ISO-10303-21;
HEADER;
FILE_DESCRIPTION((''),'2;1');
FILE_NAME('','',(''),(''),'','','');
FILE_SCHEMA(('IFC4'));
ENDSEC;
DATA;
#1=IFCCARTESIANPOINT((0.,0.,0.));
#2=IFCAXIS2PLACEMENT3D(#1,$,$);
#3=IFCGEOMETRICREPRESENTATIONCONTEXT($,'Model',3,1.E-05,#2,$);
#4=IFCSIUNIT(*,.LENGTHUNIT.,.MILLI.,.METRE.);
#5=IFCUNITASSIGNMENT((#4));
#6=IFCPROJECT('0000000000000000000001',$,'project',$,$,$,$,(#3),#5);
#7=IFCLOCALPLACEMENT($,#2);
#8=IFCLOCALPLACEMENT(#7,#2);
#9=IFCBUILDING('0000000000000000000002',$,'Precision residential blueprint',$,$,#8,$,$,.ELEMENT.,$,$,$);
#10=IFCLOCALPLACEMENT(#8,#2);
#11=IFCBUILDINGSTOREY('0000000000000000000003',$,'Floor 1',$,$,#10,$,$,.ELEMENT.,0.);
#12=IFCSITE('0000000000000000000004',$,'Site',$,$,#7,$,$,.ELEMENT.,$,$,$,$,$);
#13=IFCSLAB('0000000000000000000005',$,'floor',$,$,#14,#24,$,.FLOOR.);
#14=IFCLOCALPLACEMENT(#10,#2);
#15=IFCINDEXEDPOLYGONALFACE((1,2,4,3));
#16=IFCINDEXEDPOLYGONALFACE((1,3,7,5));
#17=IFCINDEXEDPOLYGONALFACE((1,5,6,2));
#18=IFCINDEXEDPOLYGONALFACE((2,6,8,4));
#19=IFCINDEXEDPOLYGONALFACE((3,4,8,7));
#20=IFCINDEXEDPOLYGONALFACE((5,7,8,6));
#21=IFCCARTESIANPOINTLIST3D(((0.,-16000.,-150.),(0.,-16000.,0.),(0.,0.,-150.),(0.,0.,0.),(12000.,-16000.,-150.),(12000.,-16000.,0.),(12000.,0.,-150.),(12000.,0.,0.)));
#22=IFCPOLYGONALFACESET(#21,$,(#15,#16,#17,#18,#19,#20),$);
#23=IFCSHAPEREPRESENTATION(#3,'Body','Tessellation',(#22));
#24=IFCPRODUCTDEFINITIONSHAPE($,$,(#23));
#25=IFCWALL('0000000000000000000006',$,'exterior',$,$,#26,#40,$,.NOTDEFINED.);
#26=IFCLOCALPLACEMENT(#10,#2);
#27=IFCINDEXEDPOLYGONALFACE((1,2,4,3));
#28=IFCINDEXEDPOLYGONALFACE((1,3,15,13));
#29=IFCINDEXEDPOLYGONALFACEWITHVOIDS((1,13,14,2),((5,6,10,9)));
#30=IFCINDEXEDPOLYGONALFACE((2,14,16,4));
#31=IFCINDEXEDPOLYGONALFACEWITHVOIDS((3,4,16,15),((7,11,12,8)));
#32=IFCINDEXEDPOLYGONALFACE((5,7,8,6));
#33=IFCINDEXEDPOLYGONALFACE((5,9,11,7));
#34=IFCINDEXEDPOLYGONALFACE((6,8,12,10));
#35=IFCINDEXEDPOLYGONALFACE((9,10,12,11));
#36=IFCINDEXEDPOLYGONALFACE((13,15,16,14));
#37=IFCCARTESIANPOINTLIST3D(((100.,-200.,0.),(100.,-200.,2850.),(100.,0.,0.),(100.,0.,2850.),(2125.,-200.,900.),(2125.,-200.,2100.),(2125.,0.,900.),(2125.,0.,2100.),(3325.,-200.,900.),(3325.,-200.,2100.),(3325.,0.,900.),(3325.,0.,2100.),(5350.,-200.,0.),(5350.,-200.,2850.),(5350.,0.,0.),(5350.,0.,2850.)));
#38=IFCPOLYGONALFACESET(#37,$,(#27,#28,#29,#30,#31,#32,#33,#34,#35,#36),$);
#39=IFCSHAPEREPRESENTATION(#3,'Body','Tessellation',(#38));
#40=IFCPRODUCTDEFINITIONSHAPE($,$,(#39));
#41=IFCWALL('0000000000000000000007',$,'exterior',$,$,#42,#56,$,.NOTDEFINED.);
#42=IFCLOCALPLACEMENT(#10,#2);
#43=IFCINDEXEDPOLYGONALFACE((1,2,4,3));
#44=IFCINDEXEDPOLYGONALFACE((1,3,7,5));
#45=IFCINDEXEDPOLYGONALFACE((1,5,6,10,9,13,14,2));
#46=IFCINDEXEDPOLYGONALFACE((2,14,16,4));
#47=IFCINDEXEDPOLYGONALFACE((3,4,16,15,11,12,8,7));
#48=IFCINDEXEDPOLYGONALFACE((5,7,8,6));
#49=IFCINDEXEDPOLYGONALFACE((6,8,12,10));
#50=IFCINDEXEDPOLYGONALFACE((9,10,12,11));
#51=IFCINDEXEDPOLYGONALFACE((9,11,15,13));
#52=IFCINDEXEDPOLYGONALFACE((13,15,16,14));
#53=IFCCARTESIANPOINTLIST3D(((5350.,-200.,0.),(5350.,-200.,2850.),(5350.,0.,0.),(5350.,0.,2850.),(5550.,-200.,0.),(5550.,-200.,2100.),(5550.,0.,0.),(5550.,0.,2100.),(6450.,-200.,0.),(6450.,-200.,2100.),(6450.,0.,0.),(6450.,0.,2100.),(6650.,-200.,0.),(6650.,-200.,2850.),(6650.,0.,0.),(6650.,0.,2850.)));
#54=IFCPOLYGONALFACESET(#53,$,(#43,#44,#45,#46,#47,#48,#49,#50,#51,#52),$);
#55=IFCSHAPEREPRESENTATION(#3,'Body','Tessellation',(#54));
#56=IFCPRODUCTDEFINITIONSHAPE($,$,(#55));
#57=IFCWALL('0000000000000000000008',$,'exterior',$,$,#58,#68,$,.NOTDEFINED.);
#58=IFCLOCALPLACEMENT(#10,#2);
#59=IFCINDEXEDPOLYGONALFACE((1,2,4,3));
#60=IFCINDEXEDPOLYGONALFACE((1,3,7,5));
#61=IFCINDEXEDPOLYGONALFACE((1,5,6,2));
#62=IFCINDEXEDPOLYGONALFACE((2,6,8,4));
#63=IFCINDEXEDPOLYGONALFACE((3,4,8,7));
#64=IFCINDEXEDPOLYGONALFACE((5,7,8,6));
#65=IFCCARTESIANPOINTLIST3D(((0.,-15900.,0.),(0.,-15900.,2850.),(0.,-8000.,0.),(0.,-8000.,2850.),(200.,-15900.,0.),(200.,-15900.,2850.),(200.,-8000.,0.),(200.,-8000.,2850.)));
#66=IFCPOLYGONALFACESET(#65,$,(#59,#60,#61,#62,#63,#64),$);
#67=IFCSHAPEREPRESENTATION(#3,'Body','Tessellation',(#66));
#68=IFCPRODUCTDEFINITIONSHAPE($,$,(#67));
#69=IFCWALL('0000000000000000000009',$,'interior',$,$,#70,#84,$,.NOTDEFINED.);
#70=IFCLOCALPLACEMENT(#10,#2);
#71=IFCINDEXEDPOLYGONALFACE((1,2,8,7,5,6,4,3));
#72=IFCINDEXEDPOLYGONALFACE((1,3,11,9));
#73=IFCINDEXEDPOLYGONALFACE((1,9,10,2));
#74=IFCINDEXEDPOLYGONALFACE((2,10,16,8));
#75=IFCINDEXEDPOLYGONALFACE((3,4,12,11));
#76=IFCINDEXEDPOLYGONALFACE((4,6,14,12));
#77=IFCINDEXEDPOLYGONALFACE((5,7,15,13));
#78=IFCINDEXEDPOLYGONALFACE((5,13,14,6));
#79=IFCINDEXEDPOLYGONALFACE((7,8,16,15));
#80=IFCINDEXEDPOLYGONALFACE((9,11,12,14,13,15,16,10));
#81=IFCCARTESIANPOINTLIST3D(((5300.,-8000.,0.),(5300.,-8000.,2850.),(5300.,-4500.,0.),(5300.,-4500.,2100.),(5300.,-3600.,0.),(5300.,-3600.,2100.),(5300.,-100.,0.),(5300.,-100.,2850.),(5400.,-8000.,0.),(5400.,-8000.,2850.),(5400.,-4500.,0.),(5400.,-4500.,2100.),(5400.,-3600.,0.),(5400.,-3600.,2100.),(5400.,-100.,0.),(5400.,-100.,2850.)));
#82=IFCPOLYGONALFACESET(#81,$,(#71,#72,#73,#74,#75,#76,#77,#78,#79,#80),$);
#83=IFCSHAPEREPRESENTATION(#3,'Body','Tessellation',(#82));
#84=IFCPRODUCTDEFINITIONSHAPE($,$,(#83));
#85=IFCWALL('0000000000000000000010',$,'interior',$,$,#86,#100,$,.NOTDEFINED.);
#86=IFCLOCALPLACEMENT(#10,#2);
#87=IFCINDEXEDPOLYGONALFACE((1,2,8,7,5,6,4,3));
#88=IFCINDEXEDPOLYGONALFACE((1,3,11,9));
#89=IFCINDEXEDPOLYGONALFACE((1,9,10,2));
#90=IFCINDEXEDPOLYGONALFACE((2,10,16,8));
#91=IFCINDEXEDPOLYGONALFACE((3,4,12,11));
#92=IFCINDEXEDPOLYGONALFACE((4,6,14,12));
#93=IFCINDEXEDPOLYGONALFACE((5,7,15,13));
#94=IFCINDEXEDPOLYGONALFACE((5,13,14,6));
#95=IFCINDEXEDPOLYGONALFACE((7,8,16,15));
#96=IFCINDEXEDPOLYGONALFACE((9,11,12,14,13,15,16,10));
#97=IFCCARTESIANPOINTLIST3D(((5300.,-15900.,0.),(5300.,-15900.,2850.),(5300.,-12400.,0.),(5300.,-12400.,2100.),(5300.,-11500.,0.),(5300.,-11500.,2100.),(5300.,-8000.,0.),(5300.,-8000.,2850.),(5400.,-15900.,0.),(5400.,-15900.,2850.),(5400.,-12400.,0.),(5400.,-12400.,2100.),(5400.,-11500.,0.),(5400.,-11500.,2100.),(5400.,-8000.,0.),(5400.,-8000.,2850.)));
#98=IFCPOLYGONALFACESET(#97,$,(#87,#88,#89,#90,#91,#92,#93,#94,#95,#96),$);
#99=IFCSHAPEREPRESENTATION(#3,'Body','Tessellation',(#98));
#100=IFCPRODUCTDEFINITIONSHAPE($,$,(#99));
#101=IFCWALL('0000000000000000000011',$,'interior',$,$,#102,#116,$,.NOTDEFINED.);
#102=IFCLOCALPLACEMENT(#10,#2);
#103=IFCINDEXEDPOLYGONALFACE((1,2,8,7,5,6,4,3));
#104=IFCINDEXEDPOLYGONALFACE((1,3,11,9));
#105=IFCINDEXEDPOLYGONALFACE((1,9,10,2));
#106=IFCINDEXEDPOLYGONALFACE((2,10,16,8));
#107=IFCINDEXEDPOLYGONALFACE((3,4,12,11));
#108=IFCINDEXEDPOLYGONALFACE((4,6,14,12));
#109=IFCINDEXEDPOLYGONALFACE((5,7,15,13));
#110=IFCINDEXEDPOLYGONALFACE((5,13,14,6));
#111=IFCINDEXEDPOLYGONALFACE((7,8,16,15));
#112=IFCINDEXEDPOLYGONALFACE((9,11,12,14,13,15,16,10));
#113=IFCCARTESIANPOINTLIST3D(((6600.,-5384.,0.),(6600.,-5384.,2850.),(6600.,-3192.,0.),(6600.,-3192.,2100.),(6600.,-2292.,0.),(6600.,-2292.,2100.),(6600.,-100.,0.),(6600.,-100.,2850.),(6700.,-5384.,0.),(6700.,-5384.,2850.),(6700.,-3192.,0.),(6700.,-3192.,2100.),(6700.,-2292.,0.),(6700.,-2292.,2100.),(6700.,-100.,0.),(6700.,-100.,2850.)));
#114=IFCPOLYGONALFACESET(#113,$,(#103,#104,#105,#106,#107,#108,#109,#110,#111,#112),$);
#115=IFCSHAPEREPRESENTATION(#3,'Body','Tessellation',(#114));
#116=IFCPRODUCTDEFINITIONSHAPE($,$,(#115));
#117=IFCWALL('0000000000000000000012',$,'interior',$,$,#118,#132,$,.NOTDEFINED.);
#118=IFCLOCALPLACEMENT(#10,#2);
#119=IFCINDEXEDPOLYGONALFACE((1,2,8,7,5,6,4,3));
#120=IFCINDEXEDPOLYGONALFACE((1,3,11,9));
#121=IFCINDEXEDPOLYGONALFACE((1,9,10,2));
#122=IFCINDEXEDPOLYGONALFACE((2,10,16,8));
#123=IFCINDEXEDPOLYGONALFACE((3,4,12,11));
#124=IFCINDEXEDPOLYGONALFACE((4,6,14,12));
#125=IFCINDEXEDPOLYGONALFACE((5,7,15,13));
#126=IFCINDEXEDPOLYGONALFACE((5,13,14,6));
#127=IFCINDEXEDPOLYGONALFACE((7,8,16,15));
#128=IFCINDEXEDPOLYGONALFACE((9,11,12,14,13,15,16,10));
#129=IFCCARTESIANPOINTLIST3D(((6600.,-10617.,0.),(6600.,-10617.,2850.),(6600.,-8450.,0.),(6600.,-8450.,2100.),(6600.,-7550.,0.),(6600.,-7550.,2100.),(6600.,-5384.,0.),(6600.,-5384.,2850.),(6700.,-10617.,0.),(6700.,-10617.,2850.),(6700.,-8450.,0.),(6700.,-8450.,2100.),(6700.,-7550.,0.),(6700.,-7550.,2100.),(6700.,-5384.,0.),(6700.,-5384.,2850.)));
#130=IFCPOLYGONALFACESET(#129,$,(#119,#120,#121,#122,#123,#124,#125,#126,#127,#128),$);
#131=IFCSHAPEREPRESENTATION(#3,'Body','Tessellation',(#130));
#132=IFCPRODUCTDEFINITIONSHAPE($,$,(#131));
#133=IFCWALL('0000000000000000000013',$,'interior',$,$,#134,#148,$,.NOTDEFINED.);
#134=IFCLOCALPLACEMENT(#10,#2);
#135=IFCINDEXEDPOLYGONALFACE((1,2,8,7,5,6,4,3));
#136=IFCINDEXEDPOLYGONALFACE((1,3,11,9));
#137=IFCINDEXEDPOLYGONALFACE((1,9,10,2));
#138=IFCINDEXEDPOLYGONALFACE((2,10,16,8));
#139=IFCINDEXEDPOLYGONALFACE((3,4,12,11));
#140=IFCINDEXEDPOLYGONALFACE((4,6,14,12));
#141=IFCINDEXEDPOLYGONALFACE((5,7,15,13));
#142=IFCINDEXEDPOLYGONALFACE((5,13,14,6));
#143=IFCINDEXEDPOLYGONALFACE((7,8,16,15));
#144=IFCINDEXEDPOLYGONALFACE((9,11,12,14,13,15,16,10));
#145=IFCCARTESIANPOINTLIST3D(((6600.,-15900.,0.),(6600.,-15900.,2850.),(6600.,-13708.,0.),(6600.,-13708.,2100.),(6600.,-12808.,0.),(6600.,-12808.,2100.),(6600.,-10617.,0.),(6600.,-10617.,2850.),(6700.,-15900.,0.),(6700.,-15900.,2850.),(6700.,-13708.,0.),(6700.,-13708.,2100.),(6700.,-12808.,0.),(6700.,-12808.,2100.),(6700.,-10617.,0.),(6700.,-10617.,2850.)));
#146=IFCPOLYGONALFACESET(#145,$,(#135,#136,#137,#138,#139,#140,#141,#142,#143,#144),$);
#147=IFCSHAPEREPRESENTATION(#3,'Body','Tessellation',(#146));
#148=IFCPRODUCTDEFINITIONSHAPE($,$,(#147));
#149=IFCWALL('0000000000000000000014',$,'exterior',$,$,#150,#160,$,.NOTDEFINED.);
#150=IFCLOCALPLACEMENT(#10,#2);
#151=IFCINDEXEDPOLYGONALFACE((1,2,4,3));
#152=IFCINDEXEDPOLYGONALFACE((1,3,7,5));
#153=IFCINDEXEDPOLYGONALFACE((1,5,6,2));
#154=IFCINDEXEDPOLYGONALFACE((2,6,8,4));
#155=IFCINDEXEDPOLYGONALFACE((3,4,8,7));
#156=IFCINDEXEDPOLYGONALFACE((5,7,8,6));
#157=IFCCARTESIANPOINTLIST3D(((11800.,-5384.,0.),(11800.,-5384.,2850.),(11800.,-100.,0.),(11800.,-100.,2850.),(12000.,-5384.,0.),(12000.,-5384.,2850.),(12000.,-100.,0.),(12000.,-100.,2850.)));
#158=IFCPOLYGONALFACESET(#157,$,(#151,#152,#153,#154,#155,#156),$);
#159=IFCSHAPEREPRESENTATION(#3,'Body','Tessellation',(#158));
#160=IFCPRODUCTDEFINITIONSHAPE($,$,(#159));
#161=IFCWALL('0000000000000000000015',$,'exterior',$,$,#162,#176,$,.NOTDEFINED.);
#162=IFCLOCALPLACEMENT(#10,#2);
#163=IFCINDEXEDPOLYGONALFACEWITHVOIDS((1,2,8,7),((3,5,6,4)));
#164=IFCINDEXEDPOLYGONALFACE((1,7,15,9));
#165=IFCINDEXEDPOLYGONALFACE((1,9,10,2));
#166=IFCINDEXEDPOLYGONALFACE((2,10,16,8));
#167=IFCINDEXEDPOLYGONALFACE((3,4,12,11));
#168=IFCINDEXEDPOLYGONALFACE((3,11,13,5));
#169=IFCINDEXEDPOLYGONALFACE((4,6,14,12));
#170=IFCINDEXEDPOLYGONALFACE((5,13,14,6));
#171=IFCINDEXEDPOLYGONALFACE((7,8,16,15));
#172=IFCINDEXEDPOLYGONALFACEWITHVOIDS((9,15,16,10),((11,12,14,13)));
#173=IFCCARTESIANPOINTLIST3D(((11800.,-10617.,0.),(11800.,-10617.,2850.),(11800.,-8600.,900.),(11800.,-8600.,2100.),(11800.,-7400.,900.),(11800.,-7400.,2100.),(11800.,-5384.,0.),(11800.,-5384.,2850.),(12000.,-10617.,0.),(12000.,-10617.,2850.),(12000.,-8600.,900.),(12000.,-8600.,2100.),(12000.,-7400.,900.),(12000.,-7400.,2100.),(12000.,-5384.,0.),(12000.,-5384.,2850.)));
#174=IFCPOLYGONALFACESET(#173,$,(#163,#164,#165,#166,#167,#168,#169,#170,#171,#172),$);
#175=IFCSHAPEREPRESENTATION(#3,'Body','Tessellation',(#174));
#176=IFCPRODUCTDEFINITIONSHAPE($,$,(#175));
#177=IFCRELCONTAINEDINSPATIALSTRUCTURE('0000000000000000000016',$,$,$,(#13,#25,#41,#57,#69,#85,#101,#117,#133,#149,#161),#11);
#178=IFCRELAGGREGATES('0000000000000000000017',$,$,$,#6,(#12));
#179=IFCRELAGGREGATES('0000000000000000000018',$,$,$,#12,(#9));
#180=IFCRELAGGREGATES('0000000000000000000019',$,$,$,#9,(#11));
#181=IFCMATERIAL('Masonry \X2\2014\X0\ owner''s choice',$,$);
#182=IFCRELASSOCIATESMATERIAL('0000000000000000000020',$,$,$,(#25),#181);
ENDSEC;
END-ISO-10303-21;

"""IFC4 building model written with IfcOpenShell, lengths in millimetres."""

from ifc_helpers import new_model, si_unit, frame, origin, place, context, project, spatial, polyline, outline, extrude, material, element, save


model = new_model("IFC4")

# Units and contexts
model_context = context("Model", 3, precision=1e-05, world=origin())
ifc_project = project(units=[si_unit("LENGTHUNIT", "METRE", prefix="MILLI")], contexts=[model_context])

# Site, building, storey
site_placement = place(None, origin())
site = spatial("IfcSite", under=ifc_project, at=site_placement, Name="Site", CompositionType="ELEMENT")
building_placement = place(site_placement, origin())
building = spatial("IfcBuilding", under=site, at=building_placement, Name="Precision residential blueprint", CompositionType="ELEMENT")
storey_placement = place(building_placement, origin())
storey = spatial("IfcBuildingStorey", under=building, at=storey_placement, Name="Floor 1", CompositionType="ELEMENT", Elevation=0.0)

# Slab
slab_placement = place(storey_placement, origin())
element("IfcSlab", 1, at=slab_placement, inside=storey, Name="floor", PredefinedType="FLOOR", context=model_context, shape_type="SweptSolid", body=[
    extrude(outline(polyline([(0.0, -16000.0), (12000.0, -16000.0), (12000.0, 0.0), (0.0, 0.0), (0.0, -16000.0)])), frame((0.0, 0.0, -150.0)), (0.0, 0.0, 1.0), 150.0),
])

# Walls, openings
ifc_material = material(Name="Masonry — owner's choice")
wall_1_placement = place(storey_placement, origin())
wall_1 = element("IfcWall", 2, at=wall_1_placement, inside=storey, material=ifc_material, Name="exterior", PredefinedType="NOTDEFINED", context=model_context, shape_type="SweptSolid", body=[
    extrude(outline(polyline([(100.0, 0.0), (5350.0, 0.0), (5350.0, -200.0), (100.0, -200.0), (100.0, 0.0)])), origin(), (0.0, 0.0, 1.0), 2850.0),
])
opening_1_placement = place(storey_placement, origin())
element("IfcOpeningElement", 3, at=opening_1_placement, cuts=wall_1, PredefinedType="OPENING", context=model_context, shape_type="SweptSolid", body=[
    extrude(outline(polyline([(2125.0, 0.0), (3325.0, 0.0), (3325.0, -200.0), (2125.0, -200.0), (2125.0, 0.0)])), frame((0.0, 0.0, 900.0)), (0.0, 0.0, 1.0), 1200.0),
])
wall_2_placement = place(storey_placement, origin())
wall_2 = element("IfcWall", 4, at=wall_2_placement, inside=storey, Name="exterior", PredefinedType="NOTDEFINED", context=model_context, shape_type="SweptSolid", body=[
    extrude(outline(polyline([(5350.0, 0.0), (6650.0, 0.0), (6650.0, -200.0), (5350.0, -200.0), (5350.0, 0.0)])), origin(), (0.0, 0.0, 1.0), 2850.0),
])
opening_2_placement = place(storey_placement, origin())
element("IfcOpeningElement", 5, at=opening_2_placement, cuts=wall_2, PredefinedType="OPENING", context=model_context, shape_type="SweptSolid", body=[
    extrude(outline(polyline([(5550.0, 0.0), (6450.0, 0.0), (6450.0, -200.0), (5550.0, -200.0), (5550.0, 0.0)])), origin(), (0.0, 0.0, 1.0), 2100.0),
])

# Wall
wall_3_placement = place(storey_placement, origin())
element("IfcWall", 6, at=wall_3_placement, inside=storey, Name="exterior", PredefinedType="NOTDEFINED", context=model_context, shape_type="SweptSolid", body=[
    extrude(outline(polyline([(200.0, -8000.0), (200.0, -15900.0), (0.0, -15900.0), (0.0, -8000.0), (200.0, -8000.0)])), origin(), (0.0, 0.0, 1.0), 2850.0),
])

# Walls, openings
wall_4_placement = place(storey_placement, origin())
wall_4 = element("IfcWall", 7, at=wall_4_placement, inside=storey, Name="interior", PredefinedType="NOTDEFINED", context=model_context, shape_type="SweptSolid", body=[
    extrude(outline(polyline([(5400.0, -100.0), (5400.0, -8000.0), (5300.0, -8000.0), (5300.0, -100.0), (5400.0, -100.0)])), origin(), (0.0, 0.0, 1.0), 2850.0),
])
opening_3_placement = place(storey_placement, origin())
element("IfcOpeningElement", 8, at=opening_3_placement, cuts=wall_4, PredefinedType="OPENING", context=model_context, shape_type="SweptSolid", body=[
    extrude(outline(polyline([(5400.0, -3600.0), (5400.0, -4500.0), (5300.0, -4500.0), (5300.0, -3600.0), (5400.0, -3600.0)])), origin(), (0.0, 0.0, 1.0), 2100.0),
])
wall_5_placement = place(storey_placement, origin())
wall_5 = element("IfcWall", 9, at=wall_5_placement, inside=storey, Name="interior", PredefinedType="NOTDEFINED", context=model_context, shape_type="SweptSolid", body=[
    extrude(outline(polyline([(5400.0, -8000.0), (5400.0, -15900.0), (5300.0, -15900.0), (5300.0, -8000.0), (5400.0, -8000.0)])), origin(), (0.0, 0.0, 1.0), 2850.0),
])
opening_4_placement = place(storey_placement, origin())
element("IfcOpeningElement", 10, at=opening_4_placement, cuts=wall_5, PredefinedType="OPENING", context=model_context, shape_type="SweptSolid", body=[
    extrude(outline(polyline([(5400.0, -11500.0), (5400.0, -12400.0), (5300.0, -12400.0), (5300.0, -11500.0), (5400.0, -11500.0)])), origin(), (0.0, 0.0, 1.0), 2100.0),
])
wall_6_placement = place(storey_placement, origin())
wall_6 = element("IfcWall", 11, at=wall_6_placement, inside=storey, Name="interior", PredefinedType="NOTDEFINED", context=model_context, shape_type="SweptSolid", body=[
    extrude(outline(polyline([(6700.0, -100.0), (6700.0, -5384.0), (6600.0, -5384.0), (6600.0, -100.0), (6700.0, -100.0)])), origin(), (0.0, 0.0, 1.0), 2850.0),
])
opening_5_placement = place(storey_placement, origin())
element("IfcOpeningElement", 12, at=opening_5_placement, cuts=wall_6, PredefinedType="OPENING", context=model_context, shape_type="SweptSolid", body=[
    extrude(outline(polyline([(6700.0, -2292.0), (6700.0, -3192.0), (6600.0, -3192.0), (6600.0, -2292.0), (6700.0, -2292.0)])), origin(), (0.0, 0.0, 1.0), 2100.0),
])
wall_7_placement = place(storey_placement, origin())
wall_7 = element("IfcWall", 13, at=wall_7_placement, inside=storey, Name="interior", PredefinedType="NOTDEFINED", context=model_context, shape_type="SweptSolid", body=[
    extrude(outline(polyline([(6700.0, -5384.0), (6700.0, -10617.0), (6600.0, -10617.0), (6600.0, -5384.0), (6700.0, -5384.0)])), origin(), (0.0, 0.0, 1.0), 2850.0),
])
opening_6_placement = place(storey_placement, origin())
element("IfcOpeningElement", 14, at=opening_6_placement, cuts=wall_7, PredefinedType="OPENING", context=model_context, shape_type="SweptSolid", body=[
    extrude(outline(polyline([(6700.0, -7550.0), (6700.0, -8450.0), (6600.0, -8450.0), (6600.0, -7550.0), (6700.0, -7550.0)])), origin(), (0.0, 0.0, 1.0), 2100.0),
])
wall_8_placement = place(storey_placement, origin())
wall_8 = element("IfcWall", 15, at=wall_8_placement, inside=storey, Name="interior", PredefinedType="NOTDEFINED", context=model_context, shape_type="SweptSolid", body=[
    extrude(outline(polyline([(6700.0, -10617.0), (6700.0, -15900.0), (6600.0, -15900.0), (6600.0, -10617.0), (6700.0, -10617.0)])), origin(), (0.0, 0.0, 1.0), 2850.0),
])
opening_7_placement = place(storey_placement, origin())
element("IfcOpeningElement", 16, at=opening_7_placement, cuts=wall_8, PredefinedType="OPENING", context=model_context, shape_type="SweptSolid", body=[
    extrude(outline(polyline([(6700.0, -12808.0), (6700.0, -13708.0), (6600.0, -13708.0), (6600.0, -12808.0), (6700.0, -12808.0)])), origin(), (0.0, 0.0, 1.0), 2100.0),
])

# Wall
wall_9_placement = place(storey_placement, origin())
element("IfcWall", 17, at=wall_9_placement, inside=storey, Name="exterior", PredefinedType="NOTDEFINED", context=model_context, shape_type="SweptSolid", body=[
    extrude(outline(polyline([(12000.0, -100.0), (12000.0, -5384.0), (11800.0, -5384.0), (11800.0, -100.0), (12000.0, -100.0)])), origin(), (0.0, 0.0, 1.0), 2850.0),
])

# Wall, opening
wall_10_placement = place(storey_placement, origin())
wall_10 = element("IfcWall", 18, at=wall_10_placement, inside=storey, Name="exterior", PredefinedType="NOTDEFINED", context=model_context, shape_type="SweptSolid", body=[
    extrude(outline(polyline([(12000.0, -5384.0), (12000.0, -10617.0), (11800.0, -10617.0), (11800.0, -5384.0), (12000.0, -5384.0)])), origin(), (0.0, 0.0, 1.0), 2850.0),
])
opening_8_placement = place(storey_placement, origin())
element("IfcOpeningElement", 19, at=opening_8_placement, cuts=wall_10, PredefinedType="OPENING", context=model_context, shape_type="SweptSolid", body=[
    extrude(outline(polyline([(12000.0, -7400.0), (12000.0, -8600.0), (11800.0, -8600.0), (11800.0, -7400.0), (12000.0, -7400.0)])), frame((0.0, 0.0, 900.0)), (0.0, 0.0, 1.0), 1200.0),
])

save(model, "model.ifc")
